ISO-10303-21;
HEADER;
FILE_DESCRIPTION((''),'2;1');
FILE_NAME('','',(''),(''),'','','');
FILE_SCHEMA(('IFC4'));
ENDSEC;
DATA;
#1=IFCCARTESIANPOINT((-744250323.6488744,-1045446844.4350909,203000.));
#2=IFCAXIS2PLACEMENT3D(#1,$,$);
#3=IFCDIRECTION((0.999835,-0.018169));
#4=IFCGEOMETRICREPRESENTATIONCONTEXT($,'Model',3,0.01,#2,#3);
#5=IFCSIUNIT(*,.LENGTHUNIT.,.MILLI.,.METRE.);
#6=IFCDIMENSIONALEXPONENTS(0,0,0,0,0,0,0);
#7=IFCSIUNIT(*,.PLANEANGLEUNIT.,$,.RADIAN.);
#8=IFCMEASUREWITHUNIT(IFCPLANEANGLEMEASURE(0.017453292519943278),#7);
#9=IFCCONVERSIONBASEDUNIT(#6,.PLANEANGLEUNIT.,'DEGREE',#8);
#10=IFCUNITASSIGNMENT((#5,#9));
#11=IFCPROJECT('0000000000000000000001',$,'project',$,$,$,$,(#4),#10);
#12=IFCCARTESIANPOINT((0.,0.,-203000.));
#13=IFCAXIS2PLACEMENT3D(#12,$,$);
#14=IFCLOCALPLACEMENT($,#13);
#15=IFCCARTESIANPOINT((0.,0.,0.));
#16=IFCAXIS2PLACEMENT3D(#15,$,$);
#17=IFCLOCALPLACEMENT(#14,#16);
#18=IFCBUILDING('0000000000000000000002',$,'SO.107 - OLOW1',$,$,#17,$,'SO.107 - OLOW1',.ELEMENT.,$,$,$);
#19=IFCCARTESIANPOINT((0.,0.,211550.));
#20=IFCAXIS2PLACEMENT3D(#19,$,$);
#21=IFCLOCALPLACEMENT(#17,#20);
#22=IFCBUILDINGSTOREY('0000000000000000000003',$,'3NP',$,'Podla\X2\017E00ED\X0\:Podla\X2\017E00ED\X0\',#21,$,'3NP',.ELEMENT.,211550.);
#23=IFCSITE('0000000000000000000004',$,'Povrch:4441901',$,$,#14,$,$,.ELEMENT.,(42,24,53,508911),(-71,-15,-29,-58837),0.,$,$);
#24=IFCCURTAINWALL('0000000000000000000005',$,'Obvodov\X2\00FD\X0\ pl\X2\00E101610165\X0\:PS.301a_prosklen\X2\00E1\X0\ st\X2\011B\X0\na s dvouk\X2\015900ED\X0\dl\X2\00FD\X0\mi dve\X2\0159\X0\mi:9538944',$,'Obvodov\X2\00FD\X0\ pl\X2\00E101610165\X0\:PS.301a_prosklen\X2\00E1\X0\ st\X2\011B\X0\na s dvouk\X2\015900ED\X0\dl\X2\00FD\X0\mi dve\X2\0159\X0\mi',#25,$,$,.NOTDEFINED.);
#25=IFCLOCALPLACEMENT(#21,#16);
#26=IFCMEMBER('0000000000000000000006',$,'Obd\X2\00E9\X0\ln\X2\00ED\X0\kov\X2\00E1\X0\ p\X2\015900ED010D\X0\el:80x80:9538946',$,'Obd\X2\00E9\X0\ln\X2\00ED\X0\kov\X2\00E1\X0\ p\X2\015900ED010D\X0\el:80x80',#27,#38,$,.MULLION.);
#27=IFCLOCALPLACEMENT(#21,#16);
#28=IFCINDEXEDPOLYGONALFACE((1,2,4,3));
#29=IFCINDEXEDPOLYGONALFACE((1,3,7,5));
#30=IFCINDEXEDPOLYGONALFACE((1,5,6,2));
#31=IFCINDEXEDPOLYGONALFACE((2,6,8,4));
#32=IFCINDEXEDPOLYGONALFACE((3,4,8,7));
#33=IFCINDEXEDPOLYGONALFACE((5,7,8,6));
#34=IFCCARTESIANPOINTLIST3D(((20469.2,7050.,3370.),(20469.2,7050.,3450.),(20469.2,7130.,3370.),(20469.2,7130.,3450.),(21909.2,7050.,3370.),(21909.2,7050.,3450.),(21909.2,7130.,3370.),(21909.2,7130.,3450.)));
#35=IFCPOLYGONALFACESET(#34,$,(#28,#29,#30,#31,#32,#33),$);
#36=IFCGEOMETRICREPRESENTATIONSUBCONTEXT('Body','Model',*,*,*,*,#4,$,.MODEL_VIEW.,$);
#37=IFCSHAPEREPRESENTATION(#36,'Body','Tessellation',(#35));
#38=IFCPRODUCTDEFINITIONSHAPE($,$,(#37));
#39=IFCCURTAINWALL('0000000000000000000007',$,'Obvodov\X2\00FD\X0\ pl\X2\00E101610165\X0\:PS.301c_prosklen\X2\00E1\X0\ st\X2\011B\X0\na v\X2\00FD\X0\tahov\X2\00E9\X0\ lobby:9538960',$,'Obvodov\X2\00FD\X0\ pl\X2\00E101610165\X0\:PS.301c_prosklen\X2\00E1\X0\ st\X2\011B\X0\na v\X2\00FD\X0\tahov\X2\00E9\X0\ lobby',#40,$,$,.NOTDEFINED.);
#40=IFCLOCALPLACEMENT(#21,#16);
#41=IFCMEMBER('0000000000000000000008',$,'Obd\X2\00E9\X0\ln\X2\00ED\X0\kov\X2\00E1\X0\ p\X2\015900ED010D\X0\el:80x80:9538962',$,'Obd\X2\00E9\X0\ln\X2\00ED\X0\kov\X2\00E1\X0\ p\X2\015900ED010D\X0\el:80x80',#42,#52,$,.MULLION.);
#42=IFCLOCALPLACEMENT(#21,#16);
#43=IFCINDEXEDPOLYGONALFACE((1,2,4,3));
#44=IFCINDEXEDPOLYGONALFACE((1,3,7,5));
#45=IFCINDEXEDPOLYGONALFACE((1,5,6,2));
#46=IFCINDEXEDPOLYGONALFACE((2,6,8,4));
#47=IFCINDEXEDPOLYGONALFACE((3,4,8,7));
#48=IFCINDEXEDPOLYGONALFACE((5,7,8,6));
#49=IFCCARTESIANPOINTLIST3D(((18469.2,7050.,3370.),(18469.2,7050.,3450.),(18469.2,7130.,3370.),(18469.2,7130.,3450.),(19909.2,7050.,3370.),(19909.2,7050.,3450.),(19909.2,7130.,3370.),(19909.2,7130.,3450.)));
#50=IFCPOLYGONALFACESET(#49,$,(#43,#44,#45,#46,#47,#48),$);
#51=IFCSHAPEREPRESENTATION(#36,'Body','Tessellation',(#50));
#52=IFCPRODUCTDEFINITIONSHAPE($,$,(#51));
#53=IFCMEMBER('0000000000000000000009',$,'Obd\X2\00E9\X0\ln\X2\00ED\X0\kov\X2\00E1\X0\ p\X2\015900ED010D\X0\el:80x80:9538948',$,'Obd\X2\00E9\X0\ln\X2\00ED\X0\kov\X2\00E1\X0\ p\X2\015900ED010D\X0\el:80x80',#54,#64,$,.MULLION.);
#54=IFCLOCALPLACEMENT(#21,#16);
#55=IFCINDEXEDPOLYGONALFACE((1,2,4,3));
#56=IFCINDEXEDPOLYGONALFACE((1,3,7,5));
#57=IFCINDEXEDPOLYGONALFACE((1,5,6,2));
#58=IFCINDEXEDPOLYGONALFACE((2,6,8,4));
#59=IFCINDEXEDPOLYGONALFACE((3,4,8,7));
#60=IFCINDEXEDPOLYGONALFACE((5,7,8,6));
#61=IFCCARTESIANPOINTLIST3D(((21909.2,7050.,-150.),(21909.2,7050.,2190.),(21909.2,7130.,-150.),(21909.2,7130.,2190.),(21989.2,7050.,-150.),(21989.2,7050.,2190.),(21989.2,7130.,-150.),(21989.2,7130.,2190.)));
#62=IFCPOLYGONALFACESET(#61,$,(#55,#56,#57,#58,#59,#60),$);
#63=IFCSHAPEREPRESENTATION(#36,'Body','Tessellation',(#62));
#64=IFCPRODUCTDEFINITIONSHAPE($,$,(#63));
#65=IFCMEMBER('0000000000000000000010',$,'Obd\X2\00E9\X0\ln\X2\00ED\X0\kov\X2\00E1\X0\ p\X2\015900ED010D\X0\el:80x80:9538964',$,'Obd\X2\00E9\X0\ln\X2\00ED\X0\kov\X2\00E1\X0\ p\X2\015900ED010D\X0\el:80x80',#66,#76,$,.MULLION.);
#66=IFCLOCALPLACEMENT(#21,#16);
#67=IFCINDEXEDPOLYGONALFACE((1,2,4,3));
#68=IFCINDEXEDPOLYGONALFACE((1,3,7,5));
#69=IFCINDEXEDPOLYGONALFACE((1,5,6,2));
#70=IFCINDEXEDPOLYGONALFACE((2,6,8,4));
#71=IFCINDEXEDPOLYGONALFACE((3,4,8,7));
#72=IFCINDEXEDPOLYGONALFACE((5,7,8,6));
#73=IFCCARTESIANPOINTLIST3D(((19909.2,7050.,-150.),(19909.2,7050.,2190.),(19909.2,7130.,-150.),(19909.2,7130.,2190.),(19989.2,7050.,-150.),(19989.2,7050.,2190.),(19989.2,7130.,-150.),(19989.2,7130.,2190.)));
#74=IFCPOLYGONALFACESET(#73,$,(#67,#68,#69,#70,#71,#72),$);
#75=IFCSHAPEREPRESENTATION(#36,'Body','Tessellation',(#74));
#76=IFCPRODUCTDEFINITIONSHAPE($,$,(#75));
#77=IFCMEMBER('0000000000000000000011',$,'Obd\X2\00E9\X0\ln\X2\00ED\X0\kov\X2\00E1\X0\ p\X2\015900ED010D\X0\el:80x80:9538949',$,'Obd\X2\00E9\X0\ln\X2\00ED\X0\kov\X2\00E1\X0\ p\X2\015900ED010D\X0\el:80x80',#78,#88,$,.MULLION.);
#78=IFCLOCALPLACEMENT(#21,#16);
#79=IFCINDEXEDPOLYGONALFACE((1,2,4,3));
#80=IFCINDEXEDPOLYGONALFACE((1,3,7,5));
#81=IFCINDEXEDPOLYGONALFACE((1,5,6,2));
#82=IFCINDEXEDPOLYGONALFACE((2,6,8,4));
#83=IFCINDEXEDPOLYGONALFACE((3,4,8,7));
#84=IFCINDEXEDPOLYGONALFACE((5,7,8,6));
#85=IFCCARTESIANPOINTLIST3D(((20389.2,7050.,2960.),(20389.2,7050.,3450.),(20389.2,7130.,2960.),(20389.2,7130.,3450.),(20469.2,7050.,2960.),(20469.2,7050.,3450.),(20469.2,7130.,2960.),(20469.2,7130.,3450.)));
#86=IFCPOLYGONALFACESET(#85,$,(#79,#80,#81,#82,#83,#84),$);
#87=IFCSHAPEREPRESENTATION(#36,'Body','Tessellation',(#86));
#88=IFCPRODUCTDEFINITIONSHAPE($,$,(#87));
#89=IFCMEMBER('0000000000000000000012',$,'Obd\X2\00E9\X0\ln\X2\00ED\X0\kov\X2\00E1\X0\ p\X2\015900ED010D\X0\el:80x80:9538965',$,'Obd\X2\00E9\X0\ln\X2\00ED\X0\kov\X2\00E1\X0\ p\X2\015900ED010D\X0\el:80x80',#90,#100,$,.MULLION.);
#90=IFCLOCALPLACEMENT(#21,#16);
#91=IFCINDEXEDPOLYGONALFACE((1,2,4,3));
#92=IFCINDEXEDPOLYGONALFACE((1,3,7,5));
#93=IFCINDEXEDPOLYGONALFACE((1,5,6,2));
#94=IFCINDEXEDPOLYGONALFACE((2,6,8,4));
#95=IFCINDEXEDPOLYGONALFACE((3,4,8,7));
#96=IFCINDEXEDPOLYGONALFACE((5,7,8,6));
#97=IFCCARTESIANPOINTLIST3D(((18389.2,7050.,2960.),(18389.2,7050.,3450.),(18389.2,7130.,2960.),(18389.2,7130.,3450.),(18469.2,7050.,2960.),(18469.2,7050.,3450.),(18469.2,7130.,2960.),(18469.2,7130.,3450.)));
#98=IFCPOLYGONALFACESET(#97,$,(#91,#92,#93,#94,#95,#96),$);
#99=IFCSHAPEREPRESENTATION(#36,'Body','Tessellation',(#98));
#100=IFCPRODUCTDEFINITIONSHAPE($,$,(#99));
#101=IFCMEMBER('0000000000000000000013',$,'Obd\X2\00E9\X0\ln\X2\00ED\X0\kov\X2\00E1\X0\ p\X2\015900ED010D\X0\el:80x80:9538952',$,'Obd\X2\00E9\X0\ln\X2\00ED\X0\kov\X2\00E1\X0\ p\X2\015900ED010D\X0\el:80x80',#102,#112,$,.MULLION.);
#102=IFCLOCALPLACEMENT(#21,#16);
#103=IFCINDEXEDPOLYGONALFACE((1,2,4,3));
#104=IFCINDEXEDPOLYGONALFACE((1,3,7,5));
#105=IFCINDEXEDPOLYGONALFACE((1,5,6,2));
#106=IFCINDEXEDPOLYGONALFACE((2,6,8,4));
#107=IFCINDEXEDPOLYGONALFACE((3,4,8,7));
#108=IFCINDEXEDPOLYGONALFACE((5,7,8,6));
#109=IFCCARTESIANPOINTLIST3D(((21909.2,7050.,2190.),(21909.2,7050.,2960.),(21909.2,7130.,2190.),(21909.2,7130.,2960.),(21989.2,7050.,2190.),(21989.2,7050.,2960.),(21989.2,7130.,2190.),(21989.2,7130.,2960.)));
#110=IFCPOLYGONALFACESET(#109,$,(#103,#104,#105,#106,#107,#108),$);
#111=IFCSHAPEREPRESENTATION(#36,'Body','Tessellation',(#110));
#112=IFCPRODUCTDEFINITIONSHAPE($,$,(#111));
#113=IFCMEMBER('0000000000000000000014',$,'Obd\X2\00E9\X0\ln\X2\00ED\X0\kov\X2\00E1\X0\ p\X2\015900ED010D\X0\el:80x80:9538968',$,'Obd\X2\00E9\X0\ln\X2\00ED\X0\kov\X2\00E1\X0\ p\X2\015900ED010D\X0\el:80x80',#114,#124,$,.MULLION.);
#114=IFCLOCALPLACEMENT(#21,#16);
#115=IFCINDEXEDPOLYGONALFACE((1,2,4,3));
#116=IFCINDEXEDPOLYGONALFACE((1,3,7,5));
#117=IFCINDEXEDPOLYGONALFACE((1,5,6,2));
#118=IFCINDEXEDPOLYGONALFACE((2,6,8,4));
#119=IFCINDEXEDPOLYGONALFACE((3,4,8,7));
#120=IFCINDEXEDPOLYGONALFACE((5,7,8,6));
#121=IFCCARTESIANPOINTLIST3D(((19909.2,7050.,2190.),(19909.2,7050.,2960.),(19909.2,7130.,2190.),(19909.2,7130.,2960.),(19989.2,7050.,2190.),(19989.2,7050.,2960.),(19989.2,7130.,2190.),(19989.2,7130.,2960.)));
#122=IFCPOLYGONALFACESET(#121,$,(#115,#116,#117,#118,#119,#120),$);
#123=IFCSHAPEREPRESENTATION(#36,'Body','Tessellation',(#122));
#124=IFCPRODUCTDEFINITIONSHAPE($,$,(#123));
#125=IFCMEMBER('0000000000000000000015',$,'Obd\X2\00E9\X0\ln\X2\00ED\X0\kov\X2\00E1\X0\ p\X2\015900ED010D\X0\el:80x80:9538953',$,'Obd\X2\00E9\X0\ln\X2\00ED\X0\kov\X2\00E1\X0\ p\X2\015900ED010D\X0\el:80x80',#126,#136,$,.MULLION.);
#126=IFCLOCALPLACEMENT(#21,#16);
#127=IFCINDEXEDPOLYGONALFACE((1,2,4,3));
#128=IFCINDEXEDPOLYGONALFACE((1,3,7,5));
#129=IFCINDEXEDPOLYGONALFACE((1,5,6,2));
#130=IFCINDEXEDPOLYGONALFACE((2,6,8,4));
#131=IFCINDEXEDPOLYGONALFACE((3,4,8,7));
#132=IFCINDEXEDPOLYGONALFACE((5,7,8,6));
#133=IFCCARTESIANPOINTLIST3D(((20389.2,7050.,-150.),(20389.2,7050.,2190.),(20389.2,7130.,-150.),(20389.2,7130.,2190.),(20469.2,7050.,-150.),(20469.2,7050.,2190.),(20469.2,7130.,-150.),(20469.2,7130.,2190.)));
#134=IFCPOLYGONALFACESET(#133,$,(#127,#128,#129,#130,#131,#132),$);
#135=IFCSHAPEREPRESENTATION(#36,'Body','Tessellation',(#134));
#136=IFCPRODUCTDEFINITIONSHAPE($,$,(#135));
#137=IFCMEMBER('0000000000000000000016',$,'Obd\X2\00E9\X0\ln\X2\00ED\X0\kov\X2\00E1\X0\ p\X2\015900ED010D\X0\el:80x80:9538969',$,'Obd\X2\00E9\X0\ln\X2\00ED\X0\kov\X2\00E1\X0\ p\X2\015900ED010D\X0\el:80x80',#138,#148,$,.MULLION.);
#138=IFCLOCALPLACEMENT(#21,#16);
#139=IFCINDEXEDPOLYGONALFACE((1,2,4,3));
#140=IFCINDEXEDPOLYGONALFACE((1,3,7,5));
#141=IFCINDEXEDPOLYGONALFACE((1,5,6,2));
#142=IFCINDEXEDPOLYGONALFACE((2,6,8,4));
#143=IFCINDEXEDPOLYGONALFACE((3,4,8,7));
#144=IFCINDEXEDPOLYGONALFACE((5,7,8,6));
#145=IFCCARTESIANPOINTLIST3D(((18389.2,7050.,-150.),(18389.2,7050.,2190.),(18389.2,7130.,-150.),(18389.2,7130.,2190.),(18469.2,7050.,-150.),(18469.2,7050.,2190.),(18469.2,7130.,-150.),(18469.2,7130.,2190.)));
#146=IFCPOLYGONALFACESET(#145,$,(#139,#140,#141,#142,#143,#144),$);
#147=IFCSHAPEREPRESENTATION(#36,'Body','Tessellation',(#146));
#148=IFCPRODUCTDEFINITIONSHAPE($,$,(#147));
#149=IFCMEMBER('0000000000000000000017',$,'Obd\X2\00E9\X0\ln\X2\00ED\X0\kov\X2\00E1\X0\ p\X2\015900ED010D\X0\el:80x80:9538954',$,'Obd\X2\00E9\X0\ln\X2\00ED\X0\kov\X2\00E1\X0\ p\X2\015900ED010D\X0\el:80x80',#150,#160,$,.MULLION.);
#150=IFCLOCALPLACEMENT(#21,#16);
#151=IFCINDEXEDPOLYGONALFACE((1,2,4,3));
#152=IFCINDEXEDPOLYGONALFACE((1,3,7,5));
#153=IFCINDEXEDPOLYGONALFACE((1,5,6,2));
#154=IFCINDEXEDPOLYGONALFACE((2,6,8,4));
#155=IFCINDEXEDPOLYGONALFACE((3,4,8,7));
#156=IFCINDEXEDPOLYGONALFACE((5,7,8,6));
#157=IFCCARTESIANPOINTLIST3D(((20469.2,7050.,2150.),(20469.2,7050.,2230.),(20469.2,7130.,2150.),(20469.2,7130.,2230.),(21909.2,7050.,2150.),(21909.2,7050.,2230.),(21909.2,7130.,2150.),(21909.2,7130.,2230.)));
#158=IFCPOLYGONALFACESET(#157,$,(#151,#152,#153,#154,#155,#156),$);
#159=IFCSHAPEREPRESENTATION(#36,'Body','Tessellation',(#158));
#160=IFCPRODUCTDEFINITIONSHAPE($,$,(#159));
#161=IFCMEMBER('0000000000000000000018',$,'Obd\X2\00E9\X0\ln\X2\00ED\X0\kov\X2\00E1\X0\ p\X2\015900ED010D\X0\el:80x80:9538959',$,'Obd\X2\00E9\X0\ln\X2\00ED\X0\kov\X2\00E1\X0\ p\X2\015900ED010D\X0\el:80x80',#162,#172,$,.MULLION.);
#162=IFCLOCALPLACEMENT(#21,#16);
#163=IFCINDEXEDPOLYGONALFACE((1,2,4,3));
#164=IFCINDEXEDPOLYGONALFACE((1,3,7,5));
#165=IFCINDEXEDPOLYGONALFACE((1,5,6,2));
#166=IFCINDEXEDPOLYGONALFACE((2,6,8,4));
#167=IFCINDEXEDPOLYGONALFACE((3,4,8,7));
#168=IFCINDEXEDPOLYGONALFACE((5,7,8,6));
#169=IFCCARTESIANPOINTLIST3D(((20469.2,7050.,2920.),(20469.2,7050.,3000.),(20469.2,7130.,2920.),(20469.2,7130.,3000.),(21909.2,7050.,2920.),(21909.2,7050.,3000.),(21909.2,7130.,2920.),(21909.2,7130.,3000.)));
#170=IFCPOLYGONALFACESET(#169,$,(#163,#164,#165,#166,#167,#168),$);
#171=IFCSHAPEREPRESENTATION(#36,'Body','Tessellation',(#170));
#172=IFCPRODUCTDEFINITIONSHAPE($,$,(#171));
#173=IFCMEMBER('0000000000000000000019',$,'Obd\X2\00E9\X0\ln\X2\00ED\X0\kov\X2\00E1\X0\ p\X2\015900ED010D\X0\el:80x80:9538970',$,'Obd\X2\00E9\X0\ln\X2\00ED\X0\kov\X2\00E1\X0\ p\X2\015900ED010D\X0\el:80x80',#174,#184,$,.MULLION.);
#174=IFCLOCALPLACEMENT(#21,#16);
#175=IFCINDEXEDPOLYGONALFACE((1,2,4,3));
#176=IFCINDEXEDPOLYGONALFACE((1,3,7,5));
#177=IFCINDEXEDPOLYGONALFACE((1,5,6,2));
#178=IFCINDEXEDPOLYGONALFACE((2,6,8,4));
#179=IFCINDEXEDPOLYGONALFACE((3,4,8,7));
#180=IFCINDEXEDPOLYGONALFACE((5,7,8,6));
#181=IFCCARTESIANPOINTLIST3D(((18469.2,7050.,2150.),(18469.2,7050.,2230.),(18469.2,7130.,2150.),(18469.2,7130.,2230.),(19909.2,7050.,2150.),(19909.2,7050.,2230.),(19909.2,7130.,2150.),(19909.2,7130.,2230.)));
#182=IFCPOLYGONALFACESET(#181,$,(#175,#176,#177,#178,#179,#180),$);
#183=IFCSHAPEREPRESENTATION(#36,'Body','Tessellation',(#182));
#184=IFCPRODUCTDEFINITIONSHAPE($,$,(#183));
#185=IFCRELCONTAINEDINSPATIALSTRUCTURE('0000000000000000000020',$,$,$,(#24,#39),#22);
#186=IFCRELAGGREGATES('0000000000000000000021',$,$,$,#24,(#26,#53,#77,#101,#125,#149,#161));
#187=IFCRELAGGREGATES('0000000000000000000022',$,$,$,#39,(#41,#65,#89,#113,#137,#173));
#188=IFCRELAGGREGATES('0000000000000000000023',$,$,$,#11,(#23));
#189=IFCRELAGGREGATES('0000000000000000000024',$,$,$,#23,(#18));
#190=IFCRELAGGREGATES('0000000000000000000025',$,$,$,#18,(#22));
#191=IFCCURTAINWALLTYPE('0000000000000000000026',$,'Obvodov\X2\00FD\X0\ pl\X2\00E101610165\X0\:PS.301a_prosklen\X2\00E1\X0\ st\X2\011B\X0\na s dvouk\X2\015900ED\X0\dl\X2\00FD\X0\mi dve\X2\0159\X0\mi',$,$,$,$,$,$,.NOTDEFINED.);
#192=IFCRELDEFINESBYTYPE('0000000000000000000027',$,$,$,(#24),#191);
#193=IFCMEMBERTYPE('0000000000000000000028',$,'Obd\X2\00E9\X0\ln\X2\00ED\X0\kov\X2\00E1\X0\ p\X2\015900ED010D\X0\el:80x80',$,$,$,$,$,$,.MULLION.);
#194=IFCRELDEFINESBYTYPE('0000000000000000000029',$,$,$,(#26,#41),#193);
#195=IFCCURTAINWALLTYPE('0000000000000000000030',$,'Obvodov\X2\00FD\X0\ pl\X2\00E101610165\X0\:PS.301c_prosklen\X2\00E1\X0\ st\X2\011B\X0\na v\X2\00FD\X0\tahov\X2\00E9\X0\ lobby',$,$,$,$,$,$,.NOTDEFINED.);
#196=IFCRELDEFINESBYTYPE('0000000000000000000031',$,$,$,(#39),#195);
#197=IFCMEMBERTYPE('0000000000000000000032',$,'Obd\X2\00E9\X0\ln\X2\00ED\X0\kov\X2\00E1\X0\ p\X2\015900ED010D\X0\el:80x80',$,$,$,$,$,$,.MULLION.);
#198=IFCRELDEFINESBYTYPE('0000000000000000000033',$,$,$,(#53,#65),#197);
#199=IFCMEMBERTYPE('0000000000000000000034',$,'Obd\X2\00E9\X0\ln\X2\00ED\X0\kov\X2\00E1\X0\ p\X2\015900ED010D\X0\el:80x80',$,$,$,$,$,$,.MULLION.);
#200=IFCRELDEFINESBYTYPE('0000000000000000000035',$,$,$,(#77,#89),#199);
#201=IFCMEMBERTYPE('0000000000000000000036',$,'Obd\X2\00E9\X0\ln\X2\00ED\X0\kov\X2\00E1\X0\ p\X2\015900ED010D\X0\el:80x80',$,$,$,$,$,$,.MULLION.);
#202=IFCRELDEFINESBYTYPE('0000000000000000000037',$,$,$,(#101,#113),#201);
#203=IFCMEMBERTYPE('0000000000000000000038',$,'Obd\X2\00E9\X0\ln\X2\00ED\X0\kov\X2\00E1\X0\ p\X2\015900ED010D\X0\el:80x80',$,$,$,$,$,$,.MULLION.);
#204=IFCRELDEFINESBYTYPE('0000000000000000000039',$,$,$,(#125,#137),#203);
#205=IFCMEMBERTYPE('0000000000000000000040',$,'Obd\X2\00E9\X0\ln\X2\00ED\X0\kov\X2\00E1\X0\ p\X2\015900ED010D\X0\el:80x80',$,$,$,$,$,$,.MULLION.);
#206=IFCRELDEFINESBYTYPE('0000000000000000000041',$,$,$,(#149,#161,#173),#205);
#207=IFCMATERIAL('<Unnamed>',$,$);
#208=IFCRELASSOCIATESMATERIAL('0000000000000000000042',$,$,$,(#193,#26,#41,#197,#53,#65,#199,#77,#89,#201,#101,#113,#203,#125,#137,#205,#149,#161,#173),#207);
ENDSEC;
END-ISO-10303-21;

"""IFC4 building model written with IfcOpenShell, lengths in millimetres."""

from ifc_helpers import new_model, entity, si_unit, converted_unit, direction, frame, origin, place, context, subcontext, project, spatial, indexed_curve, outline, extrude, source, transform, mapped, material, type_object, type_shapes, element, aggregate, save


model = new_model("IFC4")

# Units and contexts
model_context = context("Model", 3, precision=0.01, world=frame((-744250323.6488744, -1045446844.4350909, 203000.0)), true_north=direction((0.999835, -0.018169)))
body_context = subcontext(model_context, "Body", "Model", "MODEL_VIEW")
ifc_project = project(units=[si_unit("LENGTHUNIT", "METRE", prefix="MILLI"), converted_unit("PLANEANGLEUNIT", "DEGREE", entity("IfcPlaneAngleMeasure", 0.017453292519943278), si_unit("PLANEANGLEUNIT", "RADIAN"), dimensions=[0, 0, 0, 0, 0, 0, 0])], contexts=[model_context])

# Site, building, storey
site_placement = place(None, frame((0.0, 0.0, -203000.0)))
site = spatial("IfcSite", under=ifc_project, at=site_placement, Name="Povrch:4441901", CompositionType="ELEMENT", RefLatitude=(42, 24, 53, 508911), RefLongitude=(-71, -15, -29, -58837), RefElevation=0.0)
building_placement = place(site_placement, origin())
building = spatial("IfcBuilding", under=site, at=building_placement, Name="SO.107 - OLOW1", LongName="SO.107 - OLOW1", CompositionType="ELEMENT")
storey_placement = place(building_placement, frame((0.0, 0.0, 211550.0)))
storey = spatial("IfcBuildingStorey", under=building, at=storey_placement, Name="3NP", ObjectType="Podlaží:Podlaží", LongName="3NP", CompositionType="ELEMENT", Elevation=211550.0)

# Curtain walls, members
curtain_wall_type_1 = type_object("IfcCurtainWallType", Name="Obvodový plášť:PS.301a_prosklená stěna s dvoukřídlými dveřmi", PredefinedType="NOTDEFINED")
curtain_wall_1_placement = place(storey_placement, frame((0.0, 0.0, -211550.0)))
curtain_wall_1 = element("IfcCurtainWall", 1, at=curtain_wall_1_placement, inside=storey, type_object=curtain_wall_type_1, Name="Obvodový plášť:PS.301a_prosklená stěna s dvoukřídlými dveřmi:9538944", ObjectType="Obvodový plášť:PS.301a_prosklená stěna s dvoukřídlými dveřmi", PredefinedType="NOTDEFINED")
ifc_material_1 = material(Name="<Unnamed>")
member_type_1 = type_object("IfcMemberType", Name="Obdélníková příčel:80x80", PredefinedType="MULLION", material=ifc_material_1)
shared_shape_1 = source(origin(), body_context, "Body", "SweptSolid", [
    extrude(outline(indexed_curve([(-40.0, -40.0), (40.0, -40.0), (40.0, 40.0), (-40.0, 40.0), (-40.0, -40.0)], self_intersect=False)), frame((-40.0, 0.0, -1440.0), z_axis=(0.0, 0.0, 1.0), x_axis=(-1.0, 0.0, 0.0)), (0.0, 0.0, 1.0), 1440.0),
])
type_shapes(member_type_1, [shared_shape_1])
member_1_placement = place(curtain_wall_1_placement, frame((21909.2, 7090.0, 215000.0), z_axis=(1.0, 0.0, 0.0), x_axis=(0.0, 0.0, 1.0)))
member_1 = element("IfcMember", 2, at=member_1_placement, type_object=member_type_1, material=ifc_material_1, Name="Obdélníková příčel:80x80:9538946", ObjectType="Obdélníková příčel:80x80", PredefinedType="MULLION", context=body_context, shape_type="MappedRepresentation", body=[
    mapped(shared_shape_1, transform((0.0, 0.0, 0.0), scale=1.0)),
])
curtain_wall_type_2 = type_object("IfcCurtainWallType", Name="Obvodový plášť:PS.301c_prosklená stěna výtahové lobby", PredefinedType="NOTDEFINED")
curtain_wall_2_placement = place(storey_placement, frame((0.0, 0.0, -211550.0)))
curtain_wall_2 = element("IfcCurtainWall", 3, at=curtain_wall_2_placement, inside=storey, type_object=curtain_wall_type_2, Name="Obvodový plášť:PS.301c_prosklená stěna výtahové lobby:9538960", ObjectType="Obvodový plášť:PS.301c_prosklená stěna výtahové lobby", PredefinedType="NOTDEFINED")
member_2_placement = place(curtain_wall_2_placement, frame((19909.2, 7090.0, 215000.0), z_axis=(1.0, 0.0, 0.0), x_axis=(0.0, 0.0, 1.0)))
member_2 = element("IfcMember", 4, at=member_2_placement, type_object=member_type_1, material=ifc_material_1, Name="Obdélníková příčel:80x80:9538962", ObjectType="Obdélníková příčel:80x80", PredefinedType="MULLION", context=body_context, shape_type="MappedRepresentation", body=[
    mapped(shared_shape_1, transform((0.0, 0.0, 0.0), scale=1.0)),
])

# Members
member_type_2 = type_object("IfcMemberType", Name="Obdélníková příčel:80x80", PredefinedType="MULLION", material=ifc_material_1)
shared_shape_2 = source(origin(), body_context, "Body", "SweptSolid", [
    extrude(outline(indexed_curve([(-40.0, -40.0), (40.0, -40.0), (40.0, 40.0), (-40.0, 40.0), (-40.0, -40.0)], self_intersect=False)), frame((-40.0, 0.0, -2340.0), z_axis=(0.0, 0.0, 1.0), x_axis=(-1.0, 0.0, 0.0)), (0.0, 0.0, 1.0), 2340.0),
])
type_shapes(member_type_2, [shared_shape_2])
member_3_placement = place(curtain_wall_1_placement, frame((21989.2, 7090.0, 211400.0), z_axis=(0.0, 0.0, -1.0), x_axis=(1.0, 0.0, 0.0)))
member_3 = element("IfcMember", 5, at=member_3_placement, type_object=member_type_2, material=ifc_material_1, Name="Obdélníková příčel:80x80:9538948", ObjectType="Obdélníková příčel:80x80", PredefinedType="MULLION", context=body_context, shape_type="MappedRepresentation", body=[
    mapped(shared_shape_2, transform((0.0, 0.0, 0.0), scale=1.0)),
])
member_4_placement = place(curtain_wall_2_placement, frame((19989.2, 7090.0, 211400.0), z_axis=(0.0, 0.0, -1.0), x_axis=(1.0, 0.0, 0.0)))
member_4 = element("IfcMember", 6, at=member_4_placement, type_object=member_type_2, material=ifc_material_1, Name="Obdélníková příčel:80x80:9538964", ObjectType="Obdélníková příčel:80x80", PredefinedType="MULLION", context=body_context, shape_type="MappedRepresentation", body=[
    mapped(shared_shape_2, transform((0.0, 0.0, 0.0), scale=1.0)),
])
member_type_3 = type_object("IfcMemberType", Name="Obdélníková příčel:80x80", PredefinedType="MULLION", material=ifc_material_1)
shared_shape_3 = source(origin(), body_context, "Body", "SweptSolid", [
    extrude(outline(indexed_curve([(-40.0, -40.0), (40.0, -40.0), (40.0, 40.0), (-40.0, 40.0), (-40.0, -40.0)], self_intersect=False)), frame((-40.0, 0.0, -490.0), z_axis=(0.0, 0.0, 1.0), x_axis=(-1.0, 0.0, 0.0)), (0.0, 0.0, 1.0), 490.0),
])
type_shapes(member_type_3, [shared_shape_3])
member_5_placement = place(curtain_wall_1_placement, frame((20389.2, 7090.0, 215000.0), z_axis=(0.0, 0.0, 1.0), x_axis=(-1.0, 0.0, 0.0)))
member_5 = element("IfcMember", 7, at=member_5_placement, type_object=member_type_3, material=ifc_material_1, Name="Obdélníková příčel:80x80:9538949", ObjectType="Obdélníková příčel:80x80", PredefinedType="MULLION", context=body_context, shape_type="MappedRepresentation", body=[
    mapped(shared_shape_3, transform((0.0, 0.0, 0.0), scale=1.0)),
])
member_6_placement = place(curtain_wall_2_placement, frame((18389.2, 7090.0, 215000.0), z_axis=(0.0, 0.0, 1.0), x_axis=(-1.0, 0.0, 0.0)))
member_6 = element("IfcMember", 8, at=member_6_placement, type_object=member_type_3, material=ifc_material_1, Name="Obdélníková příčel:80x80:9538965", ObjectType="Obdélníková příčel:80x80", PredefinedType="MULLION", context=body_context, shape_type="MappedRepresentation", body=[
    mapped(shared_shape_3, transform((0.0, 0.0, 0.0), scale=1.0)),
])
member_type_4 = type_object("IfcMemberType", Name="Obdélníková příčel:80x80", PredefinedType="MULLION", material=ifc_material_1)
shared_shape_4 = source(origin(), body_context, "Body", "SweptSolid", [
    extrude(outline(indexed_curve([(-40.0, -40.0), (40.0, -40.0), (40.0, 40.0), (-40.0, 40.0), (-40.0, -40.0)], self_intersect=False)), frame((-40.0, 0.0, -770.0), z_axis=(0.0, 0.0, 1.0), x_axis=(-1.0, 0.0, 0.0)), (0.0, 0.0, 1.0), 770.0),
])
type_shapes(member_type_4, [shared_shape_4])
member_7_placement = place(curtain_wall_1_placement, frame((21989.2, 7090.0, 213740.0), z_axis=(0.0, 0.0, -1.0), x_axis=(1.0, 0.0, 0.0)))
member_7 = element("IfcMember", 9, at=member_7_placement, type_object=member_type_4, material=ifc_material_1, Name="Obdélníková příčel:80x80:9538952", ObjectType="Obdélníková příčel:80x80", PredefinedType="MULLION", context=body_context, shape_type="MappedRepresentation", body=[
    mapped(shared_shape_4, transform((0.0, 0.0, 0.0), scale=1.0)),
])
member_8_placement = place(curtain_wall_2_placement, frame((19989.2, 7090.0, 213740.0), z_axis=(0.0, 0.0, -1.0), x_axis=(1.0, 0.0, 0.0)))
member_8 = element("IfcMember", 10, at=member_8_placement, type_object=member_type_4, material=ifc_material_1, Name="Obdélníková příčel:80x80:9538968", ObjectType="Obdélníková příčel:80x80", PredefinedType="MULLION", context=body_context, shape_type="MappedRepresentation", body=[
    mapped(shared_shape_4, transform((0.0, 0.0, 0.0), scale=1.0)),
])
member_type_5 = type_object("IfcMemberType", Name="Obdélníková příčel:80x80", PredefinedType="MULLION", material=ifc_material_1)
shared_shape_5 = source(origin(), body_context, "Body", "SweptSolid", [
    extrude(outline(indexed_curve([(-40.0, -40.0), (40.0, -40.0), (40.0, 40.0), (-40.0, 40.0), (-40.0, -40.0)], self_intersect=False)), frame((-40.0, 0.0, -2340.0), z_axis=(0.0, 0.0, 1.0), x_axis=(-1.0, 0.0, 0.0)), (0.0, 0.0, 1.0), 2340.0),
])
type_shapes(member_type_5, [shared_shape_5])
member_9_placement = place(curtain_wall_1_placement, frame((20389.2, 7090.0, 213740.0), z_axis=(0.0, 0.0, 1.0), x_axis=(-1.0, 0.0, 0.0)))
member_9 = element("IfcMember", 11, at=member_9_placement, type_object=member_type_5, material=ifc_material_1, Name="Obdélníková příčel:80x80:9538953", ObjectType="Obdélníková příčel:80x80", PredefinedType="MULLION", context=body_context, shape_type="MappedRepresentation", body=[
    mapped(shared_shape_5, transform((0.0, 0.0, 0.0), scale=1.0)),
])
member_10_placement = place(curtain_wall_2_placement, frame((18389.2, 7090.0, 213740.0), z_axis=(0.0, 0.0, 1.0), x_axis=(-1.0, 0.0, 0.0)))
member_10 = element("IfcMember", 12, at=member_10_placement, type_object=member_type_5, material=ifc_material_1, Name="Obdélníková příčel:80x80:9538969", ObjectType="Obdélníková příčel:80x80", PredefinedType="MULLION", context=body_context, shape_type="MappedRepresentation", body=[
    mapped(shared_shape_5, transform((0.0, 0.0, 0.0), scale=1.0)),
])
member_type_6 = type_object("IfcMemberType", Name="Obdélníková příčel:80x80", PredefinedType="MULLION", material=ifc_material_1)
shared_shape_6 = source(origin(), body_context, "Body", "SweptSolid", [
    extrude(outline(indexed_curve([(-40.0, -40.0), (40.0, -40.0), (40.0, 40.0), (-40.0, 40.0), (-40.0, -40.0)], self_intersect=False)), frame((0.0, 0.0, -1440.0), z_axis=(0.0, 0.0, 1.0), x_axis=(-1.0, 0.0, 0.0)), (0.0, 0.0, 1.0), 1440.0),
])
type_shapes(member_type_6, [shared_shape_6])
member_11_placement = place(curtain_wall_1_placement, frame((21909.2, 7090.0, 213740.0), z_axis=(1.0, 0.0, 0.0), x_axis=(0.0, 0.0, 1.0)))
member_11 = element("IfcMember", 13, at=member_11_placement, type_object=member_type_6, material=ifc_material_1, Name="Obdélníková příčel:80x80:9538954", ObjectType="Obdélníková příčel:80x80", PredefinedType="MULLION", context=body_context, shape_type="MappedRepresentation", body=[
    mapped(shared_shape_6, transform((0.0, 0.0, 0.0), scale=1.0)),
])
member_12_placement = place(curtain_wall_1_placement, frame((21909.2, 7090.0, 214510.0), z_axis=(1.0, 0.0, 0.0), x_axis=(0.0, 0.0, 1.0)))
member_12 = element("IfcMember", 14, at=member_12_placement, type_object=member_type_6, material=ifc_material_1, Name="Obdélníková příčel:80x80:9538959", ObjectType="Obdélníková příčel:80x80", PredefinedType="MULLION", context=body_context, shape_type="MappedRepresentation", body=[
    mapped(shared_shape_6, transform((0.0, 0.0, 0.0), scale=1.0)),
])
member_13_placement = place(curtain_wall_2_placement, frame((19909.2, 7090.0, 213740.0), z_axis=(1.0, 0.0, 0.0), x_axis=(0.0, 0.0, 1.0)))
member_13 = element("IfcMember", 15, at=member_13_placement, type_object=member_type_6, material=ifc_material_1, Name="Obdélníková příčel:80x80:9538970", ObjectType="Obdélníková příčel:80x80", PredefinedType="MULLION", context=body_context, shape_type="MappedRepresentation", body=[
    mapped(shared_shape_6, transform((0.0, 0.0, 0.0), scale=1.0)),
])

aggregate(curtain_wall_1, [member_1, member_3, member_5, member_7, member_9, member_11, member_12])
aggregate(curtain_wall_2, [member_2, member_4, member_6, member_8, member_10, member_13])

save(model, "model.ifc")
